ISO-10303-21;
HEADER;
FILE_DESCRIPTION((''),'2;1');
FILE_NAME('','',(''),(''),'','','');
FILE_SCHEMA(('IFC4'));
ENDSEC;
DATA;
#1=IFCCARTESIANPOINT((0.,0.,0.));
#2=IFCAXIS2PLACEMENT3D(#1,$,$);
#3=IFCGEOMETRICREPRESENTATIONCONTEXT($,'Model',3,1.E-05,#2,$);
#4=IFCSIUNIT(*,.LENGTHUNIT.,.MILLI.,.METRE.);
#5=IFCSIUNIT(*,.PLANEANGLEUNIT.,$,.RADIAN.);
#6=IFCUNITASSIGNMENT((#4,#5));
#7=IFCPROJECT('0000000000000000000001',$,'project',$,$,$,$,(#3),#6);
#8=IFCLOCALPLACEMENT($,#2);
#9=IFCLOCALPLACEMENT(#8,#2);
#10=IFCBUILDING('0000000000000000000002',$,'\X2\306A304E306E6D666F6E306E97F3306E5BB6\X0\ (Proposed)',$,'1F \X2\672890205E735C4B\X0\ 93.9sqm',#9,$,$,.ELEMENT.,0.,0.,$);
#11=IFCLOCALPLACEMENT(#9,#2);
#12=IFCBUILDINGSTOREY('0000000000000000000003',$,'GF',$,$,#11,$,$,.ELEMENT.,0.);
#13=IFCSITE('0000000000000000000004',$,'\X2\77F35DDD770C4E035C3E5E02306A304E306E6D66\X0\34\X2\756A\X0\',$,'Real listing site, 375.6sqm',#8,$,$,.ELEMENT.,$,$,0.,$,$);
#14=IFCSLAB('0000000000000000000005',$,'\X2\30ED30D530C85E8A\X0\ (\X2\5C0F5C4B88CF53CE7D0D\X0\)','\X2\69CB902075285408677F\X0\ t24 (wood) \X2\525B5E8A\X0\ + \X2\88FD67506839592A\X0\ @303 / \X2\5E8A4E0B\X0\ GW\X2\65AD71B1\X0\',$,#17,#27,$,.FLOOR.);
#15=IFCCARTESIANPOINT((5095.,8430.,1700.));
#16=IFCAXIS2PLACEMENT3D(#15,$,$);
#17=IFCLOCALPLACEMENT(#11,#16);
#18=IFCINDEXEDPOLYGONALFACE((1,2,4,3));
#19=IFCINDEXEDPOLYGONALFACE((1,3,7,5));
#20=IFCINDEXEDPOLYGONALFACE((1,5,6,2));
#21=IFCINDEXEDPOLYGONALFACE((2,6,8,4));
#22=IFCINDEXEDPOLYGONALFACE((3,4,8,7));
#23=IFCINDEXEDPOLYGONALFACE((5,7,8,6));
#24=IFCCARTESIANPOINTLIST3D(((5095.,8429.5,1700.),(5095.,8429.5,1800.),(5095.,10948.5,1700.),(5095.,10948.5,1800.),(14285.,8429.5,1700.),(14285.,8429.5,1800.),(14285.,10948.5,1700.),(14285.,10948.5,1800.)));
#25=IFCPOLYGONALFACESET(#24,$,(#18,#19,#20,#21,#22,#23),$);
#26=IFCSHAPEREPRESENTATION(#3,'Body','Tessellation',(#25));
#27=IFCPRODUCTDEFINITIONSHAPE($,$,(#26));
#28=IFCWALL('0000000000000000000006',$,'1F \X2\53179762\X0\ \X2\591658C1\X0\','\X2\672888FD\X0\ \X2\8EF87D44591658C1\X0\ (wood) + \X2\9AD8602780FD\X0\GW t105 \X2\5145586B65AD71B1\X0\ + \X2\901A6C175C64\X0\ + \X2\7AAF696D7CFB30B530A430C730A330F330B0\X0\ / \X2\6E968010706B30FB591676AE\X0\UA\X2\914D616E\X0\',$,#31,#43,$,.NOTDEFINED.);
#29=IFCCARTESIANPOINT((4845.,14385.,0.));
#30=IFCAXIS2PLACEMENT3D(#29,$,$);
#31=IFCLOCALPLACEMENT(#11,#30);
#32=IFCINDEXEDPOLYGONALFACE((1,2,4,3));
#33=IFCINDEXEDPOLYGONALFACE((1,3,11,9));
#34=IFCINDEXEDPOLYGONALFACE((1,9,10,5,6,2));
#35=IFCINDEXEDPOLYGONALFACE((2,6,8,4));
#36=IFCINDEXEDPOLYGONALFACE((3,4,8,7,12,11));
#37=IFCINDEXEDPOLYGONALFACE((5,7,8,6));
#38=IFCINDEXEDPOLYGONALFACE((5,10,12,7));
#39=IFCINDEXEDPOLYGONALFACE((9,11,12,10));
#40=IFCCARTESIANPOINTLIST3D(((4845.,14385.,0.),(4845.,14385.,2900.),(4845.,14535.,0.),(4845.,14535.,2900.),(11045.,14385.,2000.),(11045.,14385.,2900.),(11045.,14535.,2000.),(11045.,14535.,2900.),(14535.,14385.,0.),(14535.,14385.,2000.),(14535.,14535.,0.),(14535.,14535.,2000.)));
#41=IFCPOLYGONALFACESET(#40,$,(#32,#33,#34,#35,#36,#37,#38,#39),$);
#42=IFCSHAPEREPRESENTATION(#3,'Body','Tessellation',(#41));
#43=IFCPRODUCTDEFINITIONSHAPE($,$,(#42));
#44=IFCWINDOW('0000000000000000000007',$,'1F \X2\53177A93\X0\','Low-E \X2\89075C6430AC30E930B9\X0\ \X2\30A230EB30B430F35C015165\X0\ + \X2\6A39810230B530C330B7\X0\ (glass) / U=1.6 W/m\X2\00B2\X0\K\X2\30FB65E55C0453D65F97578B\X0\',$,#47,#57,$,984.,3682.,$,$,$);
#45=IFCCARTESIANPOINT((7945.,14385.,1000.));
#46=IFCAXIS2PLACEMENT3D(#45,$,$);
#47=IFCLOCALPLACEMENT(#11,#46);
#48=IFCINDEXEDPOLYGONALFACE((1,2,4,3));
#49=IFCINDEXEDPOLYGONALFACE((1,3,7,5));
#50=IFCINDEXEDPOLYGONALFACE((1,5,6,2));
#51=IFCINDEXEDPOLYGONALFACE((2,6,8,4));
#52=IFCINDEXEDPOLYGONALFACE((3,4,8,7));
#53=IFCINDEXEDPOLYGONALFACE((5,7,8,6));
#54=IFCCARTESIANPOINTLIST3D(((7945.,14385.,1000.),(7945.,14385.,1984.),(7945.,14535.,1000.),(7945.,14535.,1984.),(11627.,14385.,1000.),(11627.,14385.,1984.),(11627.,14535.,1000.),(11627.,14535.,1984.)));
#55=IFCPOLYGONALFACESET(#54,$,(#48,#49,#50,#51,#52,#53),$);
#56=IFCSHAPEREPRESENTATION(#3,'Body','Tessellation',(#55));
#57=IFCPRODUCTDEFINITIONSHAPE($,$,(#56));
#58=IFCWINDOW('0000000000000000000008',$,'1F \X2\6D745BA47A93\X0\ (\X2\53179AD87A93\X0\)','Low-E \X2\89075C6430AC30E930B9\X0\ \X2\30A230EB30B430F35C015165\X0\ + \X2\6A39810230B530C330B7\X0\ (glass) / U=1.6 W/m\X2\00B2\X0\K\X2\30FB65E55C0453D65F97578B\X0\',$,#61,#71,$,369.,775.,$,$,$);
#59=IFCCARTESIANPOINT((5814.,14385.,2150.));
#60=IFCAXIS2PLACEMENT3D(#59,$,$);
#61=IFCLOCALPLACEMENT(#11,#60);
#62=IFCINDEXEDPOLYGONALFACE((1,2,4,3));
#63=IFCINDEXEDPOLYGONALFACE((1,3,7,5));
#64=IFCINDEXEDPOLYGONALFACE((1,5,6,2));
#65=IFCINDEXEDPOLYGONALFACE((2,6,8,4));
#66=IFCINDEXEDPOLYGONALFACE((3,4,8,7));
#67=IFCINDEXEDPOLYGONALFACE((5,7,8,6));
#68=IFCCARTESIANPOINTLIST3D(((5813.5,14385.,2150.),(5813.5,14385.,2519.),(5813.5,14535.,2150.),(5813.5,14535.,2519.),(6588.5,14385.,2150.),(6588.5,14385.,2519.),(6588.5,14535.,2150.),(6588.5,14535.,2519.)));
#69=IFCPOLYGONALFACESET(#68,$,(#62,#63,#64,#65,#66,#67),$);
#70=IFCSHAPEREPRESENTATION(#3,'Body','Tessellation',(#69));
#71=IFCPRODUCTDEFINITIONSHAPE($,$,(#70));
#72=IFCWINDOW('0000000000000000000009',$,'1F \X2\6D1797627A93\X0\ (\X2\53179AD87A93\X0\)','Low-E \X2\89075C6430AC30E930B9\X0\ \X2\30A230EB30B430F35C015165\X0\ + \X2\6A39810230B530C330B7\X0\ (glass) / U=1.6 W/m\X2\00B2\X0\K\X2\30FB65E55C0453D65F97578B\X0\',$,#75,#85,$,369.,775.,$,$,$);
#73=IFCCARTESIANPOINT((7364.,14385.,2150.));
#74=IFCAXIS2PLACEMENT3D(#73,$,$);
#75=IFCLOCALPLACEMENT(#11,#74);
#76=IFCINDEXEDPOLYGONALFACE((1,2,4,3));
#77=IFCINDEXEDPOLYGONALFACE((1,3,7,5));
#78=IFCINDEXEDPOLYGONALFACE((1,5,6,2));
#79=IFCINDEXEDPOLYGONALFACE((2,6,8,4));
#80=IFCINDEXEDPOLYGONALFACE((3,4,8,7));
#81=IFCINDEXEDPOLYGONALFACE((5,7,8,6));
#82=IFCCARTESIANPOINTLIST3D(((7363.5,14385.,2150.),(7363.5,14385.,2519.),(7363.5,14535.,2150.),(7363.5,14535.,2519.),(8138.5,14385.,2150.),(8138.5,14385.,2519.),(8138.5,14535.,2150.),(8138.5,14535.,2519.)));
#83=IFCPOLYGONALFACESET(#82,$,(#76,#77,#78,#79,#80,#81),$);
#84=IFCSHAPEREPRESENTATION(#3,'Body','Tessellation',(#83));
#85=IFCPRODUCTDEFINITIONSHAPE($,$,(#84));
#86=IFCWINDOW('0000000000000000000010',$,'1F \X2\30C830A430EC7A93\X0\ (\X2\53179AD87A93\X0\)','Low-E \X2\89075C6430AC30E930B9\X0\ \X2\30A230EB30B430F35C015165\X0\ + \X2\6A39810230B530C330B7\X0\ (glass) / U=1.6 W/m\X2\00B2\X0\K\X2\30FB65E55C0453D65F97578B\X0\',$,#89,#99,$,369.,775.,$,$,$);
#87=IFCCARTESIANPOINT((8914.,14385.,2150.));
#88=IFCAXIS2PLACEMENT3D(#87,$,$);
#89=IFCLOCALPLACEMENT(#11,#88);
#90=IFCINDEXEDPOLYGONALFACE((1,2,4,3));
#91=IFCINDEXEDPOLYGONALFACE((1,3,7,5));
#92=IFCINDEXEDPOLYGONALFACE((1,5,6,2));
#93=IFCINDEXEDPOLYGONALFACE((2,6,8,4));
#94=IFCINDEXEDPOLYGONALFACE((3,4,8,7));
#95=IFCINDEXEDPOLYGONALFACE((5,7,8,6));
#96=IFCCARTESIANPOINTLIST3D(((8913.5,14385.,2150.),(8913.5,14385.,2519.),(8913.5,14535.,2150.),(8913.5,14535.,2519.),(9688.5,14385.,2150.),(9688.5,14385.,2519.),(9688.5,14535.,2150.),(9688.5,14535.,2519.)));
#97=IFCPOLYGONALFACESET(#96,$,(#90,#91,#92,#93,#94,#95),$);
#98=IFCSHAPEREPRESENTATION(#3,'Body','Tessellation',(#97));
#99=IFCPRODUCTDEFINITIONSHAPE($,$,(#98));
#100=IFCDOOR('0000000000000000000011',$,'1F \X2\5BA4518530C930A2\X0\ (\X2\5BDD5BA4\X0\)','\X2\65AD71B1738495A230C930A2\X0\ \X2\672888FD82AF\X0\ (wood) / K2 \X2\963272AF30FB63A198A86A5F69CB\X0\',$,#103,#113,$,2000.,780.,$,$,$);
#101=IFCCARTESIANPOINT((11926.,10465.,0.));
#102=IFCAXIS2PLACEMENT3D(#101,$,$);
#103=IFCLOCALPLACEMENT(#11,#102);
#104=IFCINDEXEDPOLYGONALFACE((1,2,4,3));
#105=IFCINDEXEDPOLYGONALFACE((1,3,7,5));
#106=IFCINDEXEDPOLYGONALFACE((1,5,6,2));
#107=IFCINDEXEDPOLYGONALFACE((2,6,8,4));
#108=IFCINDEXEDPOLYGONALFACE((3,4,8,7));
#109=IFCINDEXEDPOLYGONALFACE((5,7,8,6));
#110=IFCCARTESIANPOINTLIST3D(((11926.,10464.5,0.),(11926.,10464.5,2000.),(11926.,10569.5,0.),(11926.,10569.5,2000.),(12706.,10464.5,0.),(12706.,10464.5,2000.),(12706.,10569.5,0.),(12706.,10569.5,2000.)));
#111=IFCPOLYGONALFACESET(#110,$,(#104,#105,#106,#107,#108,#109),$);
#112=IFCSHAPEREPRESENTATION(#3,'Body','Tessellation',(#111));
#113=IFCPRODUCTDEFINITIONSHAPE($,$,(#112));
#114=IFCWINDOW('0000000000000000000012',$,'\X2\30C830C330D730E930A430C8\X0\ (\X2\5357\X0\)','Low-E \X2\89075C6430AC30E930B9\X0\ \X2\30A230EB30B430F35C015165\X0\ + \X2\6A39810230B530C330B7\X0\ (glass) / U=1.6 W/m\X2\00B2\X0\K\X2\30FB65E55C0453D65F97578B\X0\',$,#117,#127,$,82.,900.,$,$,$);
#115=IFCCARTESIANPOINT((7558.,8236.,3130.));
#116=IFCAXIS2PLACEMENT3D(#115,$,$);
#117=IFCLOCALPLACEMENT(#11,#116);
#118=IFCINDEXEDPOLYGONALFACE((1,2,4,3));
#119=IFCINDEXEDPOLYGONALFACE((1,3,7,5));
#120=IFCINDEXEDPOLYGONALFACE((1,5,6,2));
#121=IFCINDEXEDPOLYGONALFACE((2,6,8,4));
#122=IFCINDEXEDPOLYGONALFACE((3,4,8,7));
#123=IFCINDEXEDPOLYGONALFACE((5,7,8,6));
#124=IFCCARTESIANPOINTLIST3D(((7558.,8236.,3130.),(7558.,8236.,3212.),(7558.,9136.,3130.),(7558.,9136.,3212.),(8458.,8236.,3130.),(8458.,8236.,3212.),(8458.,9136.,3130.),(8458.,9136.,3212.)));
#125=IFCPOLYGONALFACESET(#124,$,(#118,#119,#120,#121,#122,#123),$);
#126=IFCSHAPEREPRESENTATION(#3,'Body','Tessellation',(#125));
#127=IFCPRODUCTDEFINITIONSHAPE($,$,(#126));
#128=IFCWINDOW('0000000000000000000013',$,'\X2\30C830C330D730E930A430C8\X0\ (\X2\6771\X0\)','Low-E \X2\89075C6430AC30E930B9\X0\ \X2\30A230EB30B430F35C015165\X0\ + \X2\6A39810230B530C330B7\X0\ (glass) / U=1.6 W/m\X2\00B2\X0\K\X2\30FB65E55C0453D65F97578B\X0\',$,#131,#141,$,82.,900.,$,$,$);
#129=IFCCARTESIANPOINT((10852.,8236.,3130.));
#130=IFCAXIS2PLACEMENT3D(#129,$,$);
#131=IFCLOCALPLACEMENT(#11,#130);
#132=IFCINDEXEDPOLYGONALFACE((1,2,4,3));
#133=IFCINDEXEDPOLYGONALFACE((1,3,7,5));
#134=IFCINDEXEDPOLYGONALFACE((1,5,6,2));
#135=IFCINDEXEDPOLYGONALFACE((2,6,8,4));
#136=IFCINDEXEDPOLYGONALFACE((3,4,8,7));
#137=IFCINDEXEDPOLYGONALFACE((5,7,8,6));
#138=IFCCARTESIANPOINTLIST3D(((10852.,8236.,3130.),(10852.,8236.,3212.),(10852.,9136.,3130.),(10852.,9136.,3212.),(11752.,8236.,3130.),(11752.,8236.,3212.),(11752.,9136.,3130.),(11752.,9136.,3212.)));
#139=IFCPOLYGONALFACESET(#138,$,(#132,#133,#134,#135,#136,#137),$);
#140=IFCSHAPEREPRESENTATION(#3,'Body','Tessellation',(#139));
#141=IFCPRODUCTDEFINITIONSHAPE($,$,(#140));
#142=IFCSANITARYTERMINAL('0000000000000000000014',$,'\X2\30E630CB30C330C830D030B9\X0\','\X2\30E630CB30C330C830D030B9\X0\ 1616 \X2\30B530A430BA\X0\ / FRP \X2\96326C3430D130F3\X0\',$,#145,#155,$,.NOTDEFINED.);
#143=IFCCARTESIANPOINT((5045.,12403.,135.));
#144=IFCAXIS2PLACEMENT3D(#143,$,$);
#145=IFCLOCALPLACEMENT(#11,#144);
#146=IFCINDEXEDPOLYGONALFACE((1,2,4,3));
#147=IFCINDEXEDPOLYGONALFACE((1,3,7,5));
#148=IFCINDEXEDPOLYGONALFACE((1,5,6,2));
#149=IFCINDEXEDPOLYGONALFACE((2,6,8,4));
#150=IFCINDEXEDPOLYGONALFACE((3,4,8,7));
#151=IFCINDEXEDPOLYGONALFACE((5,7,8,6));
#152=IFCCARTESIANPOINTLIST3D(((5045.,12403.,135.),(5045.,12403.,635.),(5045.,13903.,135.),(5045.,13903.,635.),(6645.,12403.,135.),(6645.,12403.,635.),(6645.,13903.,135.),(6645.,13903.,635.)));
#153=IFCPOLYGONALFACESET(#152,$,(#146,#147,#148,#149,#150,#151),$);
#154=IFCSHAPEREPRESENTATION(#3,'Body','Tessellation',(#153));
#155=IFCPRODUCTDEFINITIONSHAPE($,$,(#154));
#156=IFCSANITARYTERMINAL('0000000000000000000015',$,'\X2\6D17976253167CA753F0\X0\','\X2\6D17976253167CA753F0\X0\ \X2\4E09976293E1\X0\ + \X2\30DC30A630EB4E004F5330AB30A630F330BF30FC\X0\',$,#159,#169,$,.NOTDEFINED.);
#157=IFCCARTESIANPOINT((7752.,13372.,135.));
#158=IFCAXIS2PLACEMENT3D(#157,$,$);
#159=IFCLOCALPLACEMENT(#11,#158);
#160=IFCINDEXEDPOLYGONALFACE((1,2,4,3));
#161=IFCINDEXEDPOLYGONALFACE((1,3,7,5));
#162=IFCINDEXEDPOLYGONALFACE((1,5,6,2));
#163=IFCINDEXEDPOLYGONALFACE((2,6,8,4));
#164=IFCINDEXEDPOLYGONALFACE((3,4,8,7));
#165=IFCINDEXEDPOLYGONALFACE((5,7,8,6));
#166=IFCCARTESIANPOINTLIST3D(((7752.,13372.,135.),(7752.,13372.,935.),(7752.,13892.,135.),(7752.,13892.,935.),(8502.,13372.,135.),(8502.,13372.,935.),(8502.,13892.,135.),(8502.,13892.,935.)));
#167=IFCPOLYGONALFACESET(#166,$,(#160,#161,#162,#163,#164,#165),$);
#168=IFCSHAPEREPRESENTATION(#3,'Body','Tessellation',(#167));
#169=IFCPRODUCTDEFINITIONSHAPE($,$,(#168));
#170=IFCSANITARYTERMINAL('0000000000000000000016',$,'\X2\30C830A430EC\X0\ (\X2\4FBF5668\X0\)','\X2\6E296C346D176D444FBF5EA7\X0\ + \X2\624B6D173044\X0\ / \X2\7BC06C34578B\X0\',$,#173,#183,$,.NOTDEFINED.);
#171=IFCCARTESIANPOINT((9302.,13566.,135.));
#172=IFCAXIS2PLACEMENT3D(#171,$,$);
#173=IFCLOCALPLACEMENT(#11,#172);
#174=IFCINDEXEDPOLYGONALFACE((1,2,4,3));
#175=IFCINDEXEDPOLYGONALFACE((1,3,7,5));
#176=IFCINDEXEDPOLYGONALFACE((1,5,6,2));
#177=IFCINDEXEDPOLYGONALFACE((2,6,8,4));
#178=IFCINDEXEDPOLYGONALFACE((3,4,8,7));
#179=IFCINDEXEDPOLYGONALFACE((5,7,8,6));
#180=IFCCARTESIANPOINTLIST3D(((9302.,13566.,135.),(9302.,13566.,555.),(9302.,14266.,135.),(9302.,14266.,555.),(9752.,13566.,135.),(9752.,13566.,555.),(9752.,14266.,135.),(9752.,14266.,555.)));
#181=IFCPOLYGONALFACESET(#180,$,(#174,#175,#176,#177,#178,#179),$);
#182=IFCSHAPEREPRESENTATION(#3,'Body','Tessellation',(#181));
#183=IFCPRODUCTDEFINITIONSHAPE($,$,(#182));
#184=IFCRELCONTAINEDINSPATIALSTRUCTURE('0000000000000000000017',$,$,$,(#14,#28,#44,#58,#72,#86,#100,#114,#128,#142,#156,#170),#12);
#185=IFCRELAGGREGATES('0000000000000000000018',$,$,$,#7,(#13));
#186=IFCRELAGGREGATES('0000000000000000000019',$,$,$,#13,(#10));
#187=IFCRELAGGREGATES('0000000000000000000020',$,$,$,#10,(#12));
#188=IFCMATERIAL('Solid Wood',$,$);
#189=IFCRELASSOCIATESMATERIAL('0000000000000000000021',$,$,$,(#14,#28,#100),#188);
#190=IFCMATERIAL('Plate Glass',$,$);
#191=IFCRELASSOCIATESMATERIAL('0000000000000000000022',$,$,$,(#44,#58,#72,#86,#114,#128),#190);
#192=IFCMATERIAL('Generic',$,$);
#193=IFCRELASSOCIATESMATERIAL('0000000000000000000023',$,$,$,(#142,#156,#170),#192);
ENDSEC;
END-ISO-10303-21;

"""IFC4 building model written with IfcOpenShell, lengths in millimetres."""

from ifc_helpers import new_model, si_unit, frame, frame_2d, origin, place, context, project, spatial, rectangle, extrude, material, element, fill, save


model = new_model("IFC4")

# Units and contexts
model_context = context("Model", 3, precision=1e-05, world=origin())
ifc_project = project(units=[si_unit("LENGTHUNIT", "METRE", prefix="MILLI"), si_unit("PLANEANGLEUNIT", "RADIAN")], contexts=[model_context])

# Site, building, storey
site_placement = place(None, origin())
site = spatial("IfcSite", under=ifc_project, at=site_placement, Name="石川県七尾市なぎの浦34番", ObjectType="Real listing site, 375.6sqm", CompositionType="ELEMENT", RefElevation=0.0)
building_placement = place(site_placement, origin())
building = spatial("IfcBuilding", under=site, at=building_placement, Name="なぎの浦潮の音の家 (Proposed)", ObjectType="1F 木造平屋 93.9sqm", CompositionType="ELEMENT", ElevationOfRefHeight=0.0, ElevationOfTerrain=0.0)
storey_placement = place(building_placement, origin())
storey = spatial("IfcBuildingStorey", under=building, at=storey_placement, Name="GF", CompositionType="ELEMENT", Elevation=0.0)

# Slab
ifc_material_1 = material(Name="Solid Wood")
slab_placement = place(storey_placement, frame((5095.0, 8430.0, 1700.0)))
element("IfcSlab", 1, at=slab_placement, inside=storey, material=ifc_material_1, Name="ロフト床 (小屋裏収納)", Description="構造用合板 t24 (wood) 剛床 + 製材根太 @303 / 床下 GW断熱", PredefinedType="FLOOR", context=model_context, shape_type="SweptSolid", body=[
    extrude(rectangle(XDim=9190.0, YDim=2519.0, at=frame_2d((4595.0, 1259.0))), frame((5095.0, 8430.0, 1700.0)), (0.0, 0.0, 1.0), 100.0),
])

# Wall, openings, windows
wall_1_placement = place(storey_placement, frame((4845.0, 14385.0, 0.0)))
wall_1 = element("IfcWall", 2, at=wall_1_placement, inside=storey, material=ifc_material_1, Name="1F 北面 外壁", Description="木製 軸組外壁 (wood) + 高性能GW t105 充填断熱 + 通気層 + 窯業系サイディング / 準耐火・外皮UA配慮", PredefinedType="NOTDEFINED", context=model_context, shape_type="SweptSolid", body=[
    extrude(rectangle(XDim=9690.0, YDim=150.0, at=frame_2d((4845.0, 75.0))), frame((4845.0, 14385.0, 0.0)), (0.0, 0.0, 1.0), 2900.0),
])
opening_1_placement = place(storey_placement, frame((7945.0, 14385.0, 1000.0)))
opening_1 = element("IfcOpeningElement", 3, at=opening_1_placement, cuts=wall_1, PredefinedType="NOTDEFINED", context=model_context, shape_type="SweptSolid", body=[
    extrude(rectangle(XDim=3682.0, YDim=150.0, at=frame_2d((1841.0, 75.0))), frame((7945.0, 14385.0, 1000.0)), (0.0, 0.0, 1.0), 984.0),
])
opening_2_placement = place(storey_placement, frame((5814.0, 14385.0, 2150.0)))
opening_2 = element("IfcOpeningElement", 4, at=opening_2_placement, cuts=wall_1, PredefinedType="NOTDEFINED", context=model_context, shape_type="SweptSolid", body=[
    extrude(rectangle(XDim=775.0, YDim=150.0, at=frame_2d((387.0, 75.0))), frame((5814.0, 14385.0, 2150.0)), (0.0, 0.0, 1.0), 369.0),
])
opening_3_placement = place(storey_placement, frame((7364.0, 14385.0, 2150.0)))
opening_3 = element("IfcOpeningElement", 5, at=opening_3_placement, cuts=wall_1, PredefinedType="NOTDEFINED", context=model_context, shape_type="SweptSolid", body=[
    extrude(rectangle(XDim=775.0, YDim=150.0, at=frame_2d((387.0, 75.0))), frame((7364.0, 14385.0, 2150.0)), (0.0, 0.0, 1.0), 369.0),
])
opening_4_placement = place(storey_placement, frame((8914.0, 14385.0, 2150.0)))
opening_4 = element("IfcOpeningElement", 6, at=opening_4_placement, cuts=wall_1, PredefinedType="NOTDEFINED", context=model_context, shape_type="SweptSolid", body=[
    extrude(rectangle(XDim=775.0, YDim=150.0, at=frame_2d((387.0, 75.0))), frame((8914.0, 14385.0, 2150.0)), (0.0, 0.0, 1.0), 369.0),
])
ifc_material_2 = material(Name="Plate Glass")
window_1_placement = place(storey_placement, frame((7945.0, 14385.0, 1000.0)))
window_1 = element("IfcWindow", 7, at=window_1_placement, inside=storey, material=ifc_material_2, Name="1F 北窓", Description="Low-E 複層ガラス アルゴン封入 + 樹脂サッシ (glass) / U=1.6 W/m²K・日射取得型", OverallHeight=984.0, OverallWidth=3682.0, context=model_context, shape_type="SweptSolid", body=[
    extrude(rectangle(XDim=3682.0, YDim=150.0, at=frame_2d((1841.0, 75.0))), frame((7945.0, 14385.0, 1000.0)), (0.0, 0.0, 1.0), 984.0),
])
fill(opening_1, window_1)
window_2_placement = place(storey_placement, frame((5814.0, 14385.0, 2150.0)))
window_2 = element("IfcWindow", 8, at=window_2_placement, inside=storey, material=ifc_material_2, Name="1F 浴室窓 (北高窓)", Description="Low-E 複層ガラス アルゴン封入 + 樹脂サッシ (glass) / U=1.6 W/m²K・日射取得型", OverallHeight=369.0, OverallWidth=775.0, context=model_context, shape_type="SweptSolid", body=[
    extrude(rectangle(XDim=775.0, YDim=150.0, at=frame_2d((387.0, 75.0))), frame((5814.0, 14385.0, 2150.0)), (0.0, 0.0, 1.0), 369.0),
])
fill(opening_2, window_2)
window_3_placement = place(storey_placement, frame((7364.0, 14385.0, 2150.0)))
window_3 = element("IfcWindow", 9, at=window_3_placement, inside=storey, material=ifc_material_2, Name="1F 洗面窓 (北高窓)", Description="Low-E 複層ガラス アルゴン封入 + 樹脂サッシ (glass) / U=1.6 W/m²K・日射取得型", OverallHeight=369.0, OverallWidth=775.0, context=model_context, shape_type="SweptSolid", body=[
    extrude(rectangle(XDim=775.0, YDim=150.0, at=frame_2d((387.0, 75.0))), frame((7364.0, 14385.0, 2150.0)), (0.0, 0.0, 1.0), 369.0),
])
fill(opening_3, window_3)
window_4_placement = place(storey_placement, frame((8914.0, 14385.0, 2150.0)))
window_4 = element("IfcWindow", 10, at=window_4_placement, inside=storey, material=ifc_material_2, Name="1F トイレ窓 (北高窓)", Description="Low-E 複層ガラス アルゴン封入 + 樹脂サッシ (glass) / U=1.6 W/m²K・日射取得型", OverallHeight=369.0, OverallWidth=775.0, context=model_context, shape_type="SweptSolid", body=[
    extrude(rectangle(XDim=775.0, YDim=150.0, at=frame_2d((387.0, 75.0))), frame((8914.0, 14385.0, 2150.0)), (0.0, 0.0, 1.0), 369.0),
])
fill(opening_4, window_4)

# Door
door_1_placement = place(storey_placement, frame((11926.0, 10465.0, 0.0)))
element("IfcDoor", 11, at=door_1_placement, inside=storey, material=ifc_material_1, Name="1F 室内ドア (寝室)", Description="断熱玄関ドア 木製芯 (wood) / K2 防犯・採風機構", OverallHeight=2000.0, OverallWidth=780.0, context=model_context, shape_type="SweptSolid", body=[
    extrude(rectangle(XDim=780.0, YDim=105.0, at=frame_2d((390.0, 52.0))), frame((11926.0, 10465.0, 0.0)), (0.0, 0.0, 1.0), 2000.0),
])

# Windows
window_5_placement = place(storey_placement, frame((7558.0, 8236.0, 3130.0)))
element("IfcWindow", 12, at=window_5_placement, inside=storey, material=ifc_material_2, Name="トップライト (南)", Description="Low-E 複層ガラス アルゴン封入 + 樹脂サッシ (glass) / U=1.6 W/m²K・日射取得型", OverallHeight=82.0, OverallWidth=900.0, context=model_context, shape_type="SweptSolid", body=[
    extrude(rectangle(XDim=900.0, YDim=900.0, at=frame_2d((450.0, 450.0))), frame((7558.0, 8236.0, 3130.0)), (0.0, 0.0, 1.0), 82.0),
])
window_6_placement = place(storey_placement, frame((10852.0, 8236.0, 3130.0)))
element("IfcWindow", 13, at=window_6_placement, inside=storey, material=ifc_material_2, Name="トップライト (東)", Description="Low-E 複層ガラス アルゴン封入 + 樹脂サッシ (glass) / U=1.6 W/m²K・日射取得型", OverallHeight=82.0, OverallWidth=900.0, context=model_context, shape_type="SweptSolid", body=[
    extrude(rectangle(XDim=900.0, YDim=900.0, at=frame_2d((450.0, 450.0))), frame((10852.0, 8236.0, 3130.0)), (0.0, 0.0, 1.0), 82.0),
])

# Sanitary terminals
ifc_material_3 = material(Name="Generic")
sanitary_terminal_1_placement = place(storey_placement, frame((5045.0, 12403.0, 135.0)))
element("IfcSanitaryTerminal", 14, at=sanitary_terminal_1_placement, inside=storey, material=ifc_material_3, Name="ユニットバス", Description="ユニットバス 1616 サイズ / FRP 防水パン", PredefinedType="NOTDEFINED", context=model_context, shape_type="SweptSolid", body=[
    extrude(rectangle(XDim=1600.0, YDim=1500.0, at=frame_2d((800.0, 750.0))), frame((5045.0, 12403.0, 135.0)), (0.0, 0.0, 1.0), 500.0),
])
sanitary_terminal_2_placement = place(storey_placement, frame((7752.0, 13372.0, 135.0)))
element("IfcSanitaryTerminal", 15, at=sanitary_terminal_2_placement, inside=storey, material=ifc_material_3, Name="洗面化粧台", Description="洗面化粧台 三面鏡 + ボウル一体カウンター", PredefinedType="NOTDEFINED", context=model_context, shape_type="SweptSolid", body=[
    extrude(rectangle(XDim=750.0, YDim=520.0, at=frame_2d((375.0, 260.0))), frame((7752.0, 13372.0, 135.0)), (0.0, 0.0, 1.0), 800.0),
])
sanitary_terminal_3_placement = place(storey_placement, frame((9302.0, 13566.0, 135.0)))
element("IfcSanitaryTerminal", 16, at=sanitary_terminal_3_placement, inside=storey, material=ifc_material_3, Name="トイレ (便器)", Description="温水洗浄便座 + 手洗い / 節水型", PredefinedType="NOTDEFINED", context=model_context, shape_type="SweptSolid", body=[
    extrude(rectangle(XDim=450.0, YDim=700.0, at=frame_2d((225.0, 350.0))), frame((9302.0, 13566.0, 135.0)), (0.0, 0.0, 1.0), 420.0),
])

save(model, "model.ifc")
